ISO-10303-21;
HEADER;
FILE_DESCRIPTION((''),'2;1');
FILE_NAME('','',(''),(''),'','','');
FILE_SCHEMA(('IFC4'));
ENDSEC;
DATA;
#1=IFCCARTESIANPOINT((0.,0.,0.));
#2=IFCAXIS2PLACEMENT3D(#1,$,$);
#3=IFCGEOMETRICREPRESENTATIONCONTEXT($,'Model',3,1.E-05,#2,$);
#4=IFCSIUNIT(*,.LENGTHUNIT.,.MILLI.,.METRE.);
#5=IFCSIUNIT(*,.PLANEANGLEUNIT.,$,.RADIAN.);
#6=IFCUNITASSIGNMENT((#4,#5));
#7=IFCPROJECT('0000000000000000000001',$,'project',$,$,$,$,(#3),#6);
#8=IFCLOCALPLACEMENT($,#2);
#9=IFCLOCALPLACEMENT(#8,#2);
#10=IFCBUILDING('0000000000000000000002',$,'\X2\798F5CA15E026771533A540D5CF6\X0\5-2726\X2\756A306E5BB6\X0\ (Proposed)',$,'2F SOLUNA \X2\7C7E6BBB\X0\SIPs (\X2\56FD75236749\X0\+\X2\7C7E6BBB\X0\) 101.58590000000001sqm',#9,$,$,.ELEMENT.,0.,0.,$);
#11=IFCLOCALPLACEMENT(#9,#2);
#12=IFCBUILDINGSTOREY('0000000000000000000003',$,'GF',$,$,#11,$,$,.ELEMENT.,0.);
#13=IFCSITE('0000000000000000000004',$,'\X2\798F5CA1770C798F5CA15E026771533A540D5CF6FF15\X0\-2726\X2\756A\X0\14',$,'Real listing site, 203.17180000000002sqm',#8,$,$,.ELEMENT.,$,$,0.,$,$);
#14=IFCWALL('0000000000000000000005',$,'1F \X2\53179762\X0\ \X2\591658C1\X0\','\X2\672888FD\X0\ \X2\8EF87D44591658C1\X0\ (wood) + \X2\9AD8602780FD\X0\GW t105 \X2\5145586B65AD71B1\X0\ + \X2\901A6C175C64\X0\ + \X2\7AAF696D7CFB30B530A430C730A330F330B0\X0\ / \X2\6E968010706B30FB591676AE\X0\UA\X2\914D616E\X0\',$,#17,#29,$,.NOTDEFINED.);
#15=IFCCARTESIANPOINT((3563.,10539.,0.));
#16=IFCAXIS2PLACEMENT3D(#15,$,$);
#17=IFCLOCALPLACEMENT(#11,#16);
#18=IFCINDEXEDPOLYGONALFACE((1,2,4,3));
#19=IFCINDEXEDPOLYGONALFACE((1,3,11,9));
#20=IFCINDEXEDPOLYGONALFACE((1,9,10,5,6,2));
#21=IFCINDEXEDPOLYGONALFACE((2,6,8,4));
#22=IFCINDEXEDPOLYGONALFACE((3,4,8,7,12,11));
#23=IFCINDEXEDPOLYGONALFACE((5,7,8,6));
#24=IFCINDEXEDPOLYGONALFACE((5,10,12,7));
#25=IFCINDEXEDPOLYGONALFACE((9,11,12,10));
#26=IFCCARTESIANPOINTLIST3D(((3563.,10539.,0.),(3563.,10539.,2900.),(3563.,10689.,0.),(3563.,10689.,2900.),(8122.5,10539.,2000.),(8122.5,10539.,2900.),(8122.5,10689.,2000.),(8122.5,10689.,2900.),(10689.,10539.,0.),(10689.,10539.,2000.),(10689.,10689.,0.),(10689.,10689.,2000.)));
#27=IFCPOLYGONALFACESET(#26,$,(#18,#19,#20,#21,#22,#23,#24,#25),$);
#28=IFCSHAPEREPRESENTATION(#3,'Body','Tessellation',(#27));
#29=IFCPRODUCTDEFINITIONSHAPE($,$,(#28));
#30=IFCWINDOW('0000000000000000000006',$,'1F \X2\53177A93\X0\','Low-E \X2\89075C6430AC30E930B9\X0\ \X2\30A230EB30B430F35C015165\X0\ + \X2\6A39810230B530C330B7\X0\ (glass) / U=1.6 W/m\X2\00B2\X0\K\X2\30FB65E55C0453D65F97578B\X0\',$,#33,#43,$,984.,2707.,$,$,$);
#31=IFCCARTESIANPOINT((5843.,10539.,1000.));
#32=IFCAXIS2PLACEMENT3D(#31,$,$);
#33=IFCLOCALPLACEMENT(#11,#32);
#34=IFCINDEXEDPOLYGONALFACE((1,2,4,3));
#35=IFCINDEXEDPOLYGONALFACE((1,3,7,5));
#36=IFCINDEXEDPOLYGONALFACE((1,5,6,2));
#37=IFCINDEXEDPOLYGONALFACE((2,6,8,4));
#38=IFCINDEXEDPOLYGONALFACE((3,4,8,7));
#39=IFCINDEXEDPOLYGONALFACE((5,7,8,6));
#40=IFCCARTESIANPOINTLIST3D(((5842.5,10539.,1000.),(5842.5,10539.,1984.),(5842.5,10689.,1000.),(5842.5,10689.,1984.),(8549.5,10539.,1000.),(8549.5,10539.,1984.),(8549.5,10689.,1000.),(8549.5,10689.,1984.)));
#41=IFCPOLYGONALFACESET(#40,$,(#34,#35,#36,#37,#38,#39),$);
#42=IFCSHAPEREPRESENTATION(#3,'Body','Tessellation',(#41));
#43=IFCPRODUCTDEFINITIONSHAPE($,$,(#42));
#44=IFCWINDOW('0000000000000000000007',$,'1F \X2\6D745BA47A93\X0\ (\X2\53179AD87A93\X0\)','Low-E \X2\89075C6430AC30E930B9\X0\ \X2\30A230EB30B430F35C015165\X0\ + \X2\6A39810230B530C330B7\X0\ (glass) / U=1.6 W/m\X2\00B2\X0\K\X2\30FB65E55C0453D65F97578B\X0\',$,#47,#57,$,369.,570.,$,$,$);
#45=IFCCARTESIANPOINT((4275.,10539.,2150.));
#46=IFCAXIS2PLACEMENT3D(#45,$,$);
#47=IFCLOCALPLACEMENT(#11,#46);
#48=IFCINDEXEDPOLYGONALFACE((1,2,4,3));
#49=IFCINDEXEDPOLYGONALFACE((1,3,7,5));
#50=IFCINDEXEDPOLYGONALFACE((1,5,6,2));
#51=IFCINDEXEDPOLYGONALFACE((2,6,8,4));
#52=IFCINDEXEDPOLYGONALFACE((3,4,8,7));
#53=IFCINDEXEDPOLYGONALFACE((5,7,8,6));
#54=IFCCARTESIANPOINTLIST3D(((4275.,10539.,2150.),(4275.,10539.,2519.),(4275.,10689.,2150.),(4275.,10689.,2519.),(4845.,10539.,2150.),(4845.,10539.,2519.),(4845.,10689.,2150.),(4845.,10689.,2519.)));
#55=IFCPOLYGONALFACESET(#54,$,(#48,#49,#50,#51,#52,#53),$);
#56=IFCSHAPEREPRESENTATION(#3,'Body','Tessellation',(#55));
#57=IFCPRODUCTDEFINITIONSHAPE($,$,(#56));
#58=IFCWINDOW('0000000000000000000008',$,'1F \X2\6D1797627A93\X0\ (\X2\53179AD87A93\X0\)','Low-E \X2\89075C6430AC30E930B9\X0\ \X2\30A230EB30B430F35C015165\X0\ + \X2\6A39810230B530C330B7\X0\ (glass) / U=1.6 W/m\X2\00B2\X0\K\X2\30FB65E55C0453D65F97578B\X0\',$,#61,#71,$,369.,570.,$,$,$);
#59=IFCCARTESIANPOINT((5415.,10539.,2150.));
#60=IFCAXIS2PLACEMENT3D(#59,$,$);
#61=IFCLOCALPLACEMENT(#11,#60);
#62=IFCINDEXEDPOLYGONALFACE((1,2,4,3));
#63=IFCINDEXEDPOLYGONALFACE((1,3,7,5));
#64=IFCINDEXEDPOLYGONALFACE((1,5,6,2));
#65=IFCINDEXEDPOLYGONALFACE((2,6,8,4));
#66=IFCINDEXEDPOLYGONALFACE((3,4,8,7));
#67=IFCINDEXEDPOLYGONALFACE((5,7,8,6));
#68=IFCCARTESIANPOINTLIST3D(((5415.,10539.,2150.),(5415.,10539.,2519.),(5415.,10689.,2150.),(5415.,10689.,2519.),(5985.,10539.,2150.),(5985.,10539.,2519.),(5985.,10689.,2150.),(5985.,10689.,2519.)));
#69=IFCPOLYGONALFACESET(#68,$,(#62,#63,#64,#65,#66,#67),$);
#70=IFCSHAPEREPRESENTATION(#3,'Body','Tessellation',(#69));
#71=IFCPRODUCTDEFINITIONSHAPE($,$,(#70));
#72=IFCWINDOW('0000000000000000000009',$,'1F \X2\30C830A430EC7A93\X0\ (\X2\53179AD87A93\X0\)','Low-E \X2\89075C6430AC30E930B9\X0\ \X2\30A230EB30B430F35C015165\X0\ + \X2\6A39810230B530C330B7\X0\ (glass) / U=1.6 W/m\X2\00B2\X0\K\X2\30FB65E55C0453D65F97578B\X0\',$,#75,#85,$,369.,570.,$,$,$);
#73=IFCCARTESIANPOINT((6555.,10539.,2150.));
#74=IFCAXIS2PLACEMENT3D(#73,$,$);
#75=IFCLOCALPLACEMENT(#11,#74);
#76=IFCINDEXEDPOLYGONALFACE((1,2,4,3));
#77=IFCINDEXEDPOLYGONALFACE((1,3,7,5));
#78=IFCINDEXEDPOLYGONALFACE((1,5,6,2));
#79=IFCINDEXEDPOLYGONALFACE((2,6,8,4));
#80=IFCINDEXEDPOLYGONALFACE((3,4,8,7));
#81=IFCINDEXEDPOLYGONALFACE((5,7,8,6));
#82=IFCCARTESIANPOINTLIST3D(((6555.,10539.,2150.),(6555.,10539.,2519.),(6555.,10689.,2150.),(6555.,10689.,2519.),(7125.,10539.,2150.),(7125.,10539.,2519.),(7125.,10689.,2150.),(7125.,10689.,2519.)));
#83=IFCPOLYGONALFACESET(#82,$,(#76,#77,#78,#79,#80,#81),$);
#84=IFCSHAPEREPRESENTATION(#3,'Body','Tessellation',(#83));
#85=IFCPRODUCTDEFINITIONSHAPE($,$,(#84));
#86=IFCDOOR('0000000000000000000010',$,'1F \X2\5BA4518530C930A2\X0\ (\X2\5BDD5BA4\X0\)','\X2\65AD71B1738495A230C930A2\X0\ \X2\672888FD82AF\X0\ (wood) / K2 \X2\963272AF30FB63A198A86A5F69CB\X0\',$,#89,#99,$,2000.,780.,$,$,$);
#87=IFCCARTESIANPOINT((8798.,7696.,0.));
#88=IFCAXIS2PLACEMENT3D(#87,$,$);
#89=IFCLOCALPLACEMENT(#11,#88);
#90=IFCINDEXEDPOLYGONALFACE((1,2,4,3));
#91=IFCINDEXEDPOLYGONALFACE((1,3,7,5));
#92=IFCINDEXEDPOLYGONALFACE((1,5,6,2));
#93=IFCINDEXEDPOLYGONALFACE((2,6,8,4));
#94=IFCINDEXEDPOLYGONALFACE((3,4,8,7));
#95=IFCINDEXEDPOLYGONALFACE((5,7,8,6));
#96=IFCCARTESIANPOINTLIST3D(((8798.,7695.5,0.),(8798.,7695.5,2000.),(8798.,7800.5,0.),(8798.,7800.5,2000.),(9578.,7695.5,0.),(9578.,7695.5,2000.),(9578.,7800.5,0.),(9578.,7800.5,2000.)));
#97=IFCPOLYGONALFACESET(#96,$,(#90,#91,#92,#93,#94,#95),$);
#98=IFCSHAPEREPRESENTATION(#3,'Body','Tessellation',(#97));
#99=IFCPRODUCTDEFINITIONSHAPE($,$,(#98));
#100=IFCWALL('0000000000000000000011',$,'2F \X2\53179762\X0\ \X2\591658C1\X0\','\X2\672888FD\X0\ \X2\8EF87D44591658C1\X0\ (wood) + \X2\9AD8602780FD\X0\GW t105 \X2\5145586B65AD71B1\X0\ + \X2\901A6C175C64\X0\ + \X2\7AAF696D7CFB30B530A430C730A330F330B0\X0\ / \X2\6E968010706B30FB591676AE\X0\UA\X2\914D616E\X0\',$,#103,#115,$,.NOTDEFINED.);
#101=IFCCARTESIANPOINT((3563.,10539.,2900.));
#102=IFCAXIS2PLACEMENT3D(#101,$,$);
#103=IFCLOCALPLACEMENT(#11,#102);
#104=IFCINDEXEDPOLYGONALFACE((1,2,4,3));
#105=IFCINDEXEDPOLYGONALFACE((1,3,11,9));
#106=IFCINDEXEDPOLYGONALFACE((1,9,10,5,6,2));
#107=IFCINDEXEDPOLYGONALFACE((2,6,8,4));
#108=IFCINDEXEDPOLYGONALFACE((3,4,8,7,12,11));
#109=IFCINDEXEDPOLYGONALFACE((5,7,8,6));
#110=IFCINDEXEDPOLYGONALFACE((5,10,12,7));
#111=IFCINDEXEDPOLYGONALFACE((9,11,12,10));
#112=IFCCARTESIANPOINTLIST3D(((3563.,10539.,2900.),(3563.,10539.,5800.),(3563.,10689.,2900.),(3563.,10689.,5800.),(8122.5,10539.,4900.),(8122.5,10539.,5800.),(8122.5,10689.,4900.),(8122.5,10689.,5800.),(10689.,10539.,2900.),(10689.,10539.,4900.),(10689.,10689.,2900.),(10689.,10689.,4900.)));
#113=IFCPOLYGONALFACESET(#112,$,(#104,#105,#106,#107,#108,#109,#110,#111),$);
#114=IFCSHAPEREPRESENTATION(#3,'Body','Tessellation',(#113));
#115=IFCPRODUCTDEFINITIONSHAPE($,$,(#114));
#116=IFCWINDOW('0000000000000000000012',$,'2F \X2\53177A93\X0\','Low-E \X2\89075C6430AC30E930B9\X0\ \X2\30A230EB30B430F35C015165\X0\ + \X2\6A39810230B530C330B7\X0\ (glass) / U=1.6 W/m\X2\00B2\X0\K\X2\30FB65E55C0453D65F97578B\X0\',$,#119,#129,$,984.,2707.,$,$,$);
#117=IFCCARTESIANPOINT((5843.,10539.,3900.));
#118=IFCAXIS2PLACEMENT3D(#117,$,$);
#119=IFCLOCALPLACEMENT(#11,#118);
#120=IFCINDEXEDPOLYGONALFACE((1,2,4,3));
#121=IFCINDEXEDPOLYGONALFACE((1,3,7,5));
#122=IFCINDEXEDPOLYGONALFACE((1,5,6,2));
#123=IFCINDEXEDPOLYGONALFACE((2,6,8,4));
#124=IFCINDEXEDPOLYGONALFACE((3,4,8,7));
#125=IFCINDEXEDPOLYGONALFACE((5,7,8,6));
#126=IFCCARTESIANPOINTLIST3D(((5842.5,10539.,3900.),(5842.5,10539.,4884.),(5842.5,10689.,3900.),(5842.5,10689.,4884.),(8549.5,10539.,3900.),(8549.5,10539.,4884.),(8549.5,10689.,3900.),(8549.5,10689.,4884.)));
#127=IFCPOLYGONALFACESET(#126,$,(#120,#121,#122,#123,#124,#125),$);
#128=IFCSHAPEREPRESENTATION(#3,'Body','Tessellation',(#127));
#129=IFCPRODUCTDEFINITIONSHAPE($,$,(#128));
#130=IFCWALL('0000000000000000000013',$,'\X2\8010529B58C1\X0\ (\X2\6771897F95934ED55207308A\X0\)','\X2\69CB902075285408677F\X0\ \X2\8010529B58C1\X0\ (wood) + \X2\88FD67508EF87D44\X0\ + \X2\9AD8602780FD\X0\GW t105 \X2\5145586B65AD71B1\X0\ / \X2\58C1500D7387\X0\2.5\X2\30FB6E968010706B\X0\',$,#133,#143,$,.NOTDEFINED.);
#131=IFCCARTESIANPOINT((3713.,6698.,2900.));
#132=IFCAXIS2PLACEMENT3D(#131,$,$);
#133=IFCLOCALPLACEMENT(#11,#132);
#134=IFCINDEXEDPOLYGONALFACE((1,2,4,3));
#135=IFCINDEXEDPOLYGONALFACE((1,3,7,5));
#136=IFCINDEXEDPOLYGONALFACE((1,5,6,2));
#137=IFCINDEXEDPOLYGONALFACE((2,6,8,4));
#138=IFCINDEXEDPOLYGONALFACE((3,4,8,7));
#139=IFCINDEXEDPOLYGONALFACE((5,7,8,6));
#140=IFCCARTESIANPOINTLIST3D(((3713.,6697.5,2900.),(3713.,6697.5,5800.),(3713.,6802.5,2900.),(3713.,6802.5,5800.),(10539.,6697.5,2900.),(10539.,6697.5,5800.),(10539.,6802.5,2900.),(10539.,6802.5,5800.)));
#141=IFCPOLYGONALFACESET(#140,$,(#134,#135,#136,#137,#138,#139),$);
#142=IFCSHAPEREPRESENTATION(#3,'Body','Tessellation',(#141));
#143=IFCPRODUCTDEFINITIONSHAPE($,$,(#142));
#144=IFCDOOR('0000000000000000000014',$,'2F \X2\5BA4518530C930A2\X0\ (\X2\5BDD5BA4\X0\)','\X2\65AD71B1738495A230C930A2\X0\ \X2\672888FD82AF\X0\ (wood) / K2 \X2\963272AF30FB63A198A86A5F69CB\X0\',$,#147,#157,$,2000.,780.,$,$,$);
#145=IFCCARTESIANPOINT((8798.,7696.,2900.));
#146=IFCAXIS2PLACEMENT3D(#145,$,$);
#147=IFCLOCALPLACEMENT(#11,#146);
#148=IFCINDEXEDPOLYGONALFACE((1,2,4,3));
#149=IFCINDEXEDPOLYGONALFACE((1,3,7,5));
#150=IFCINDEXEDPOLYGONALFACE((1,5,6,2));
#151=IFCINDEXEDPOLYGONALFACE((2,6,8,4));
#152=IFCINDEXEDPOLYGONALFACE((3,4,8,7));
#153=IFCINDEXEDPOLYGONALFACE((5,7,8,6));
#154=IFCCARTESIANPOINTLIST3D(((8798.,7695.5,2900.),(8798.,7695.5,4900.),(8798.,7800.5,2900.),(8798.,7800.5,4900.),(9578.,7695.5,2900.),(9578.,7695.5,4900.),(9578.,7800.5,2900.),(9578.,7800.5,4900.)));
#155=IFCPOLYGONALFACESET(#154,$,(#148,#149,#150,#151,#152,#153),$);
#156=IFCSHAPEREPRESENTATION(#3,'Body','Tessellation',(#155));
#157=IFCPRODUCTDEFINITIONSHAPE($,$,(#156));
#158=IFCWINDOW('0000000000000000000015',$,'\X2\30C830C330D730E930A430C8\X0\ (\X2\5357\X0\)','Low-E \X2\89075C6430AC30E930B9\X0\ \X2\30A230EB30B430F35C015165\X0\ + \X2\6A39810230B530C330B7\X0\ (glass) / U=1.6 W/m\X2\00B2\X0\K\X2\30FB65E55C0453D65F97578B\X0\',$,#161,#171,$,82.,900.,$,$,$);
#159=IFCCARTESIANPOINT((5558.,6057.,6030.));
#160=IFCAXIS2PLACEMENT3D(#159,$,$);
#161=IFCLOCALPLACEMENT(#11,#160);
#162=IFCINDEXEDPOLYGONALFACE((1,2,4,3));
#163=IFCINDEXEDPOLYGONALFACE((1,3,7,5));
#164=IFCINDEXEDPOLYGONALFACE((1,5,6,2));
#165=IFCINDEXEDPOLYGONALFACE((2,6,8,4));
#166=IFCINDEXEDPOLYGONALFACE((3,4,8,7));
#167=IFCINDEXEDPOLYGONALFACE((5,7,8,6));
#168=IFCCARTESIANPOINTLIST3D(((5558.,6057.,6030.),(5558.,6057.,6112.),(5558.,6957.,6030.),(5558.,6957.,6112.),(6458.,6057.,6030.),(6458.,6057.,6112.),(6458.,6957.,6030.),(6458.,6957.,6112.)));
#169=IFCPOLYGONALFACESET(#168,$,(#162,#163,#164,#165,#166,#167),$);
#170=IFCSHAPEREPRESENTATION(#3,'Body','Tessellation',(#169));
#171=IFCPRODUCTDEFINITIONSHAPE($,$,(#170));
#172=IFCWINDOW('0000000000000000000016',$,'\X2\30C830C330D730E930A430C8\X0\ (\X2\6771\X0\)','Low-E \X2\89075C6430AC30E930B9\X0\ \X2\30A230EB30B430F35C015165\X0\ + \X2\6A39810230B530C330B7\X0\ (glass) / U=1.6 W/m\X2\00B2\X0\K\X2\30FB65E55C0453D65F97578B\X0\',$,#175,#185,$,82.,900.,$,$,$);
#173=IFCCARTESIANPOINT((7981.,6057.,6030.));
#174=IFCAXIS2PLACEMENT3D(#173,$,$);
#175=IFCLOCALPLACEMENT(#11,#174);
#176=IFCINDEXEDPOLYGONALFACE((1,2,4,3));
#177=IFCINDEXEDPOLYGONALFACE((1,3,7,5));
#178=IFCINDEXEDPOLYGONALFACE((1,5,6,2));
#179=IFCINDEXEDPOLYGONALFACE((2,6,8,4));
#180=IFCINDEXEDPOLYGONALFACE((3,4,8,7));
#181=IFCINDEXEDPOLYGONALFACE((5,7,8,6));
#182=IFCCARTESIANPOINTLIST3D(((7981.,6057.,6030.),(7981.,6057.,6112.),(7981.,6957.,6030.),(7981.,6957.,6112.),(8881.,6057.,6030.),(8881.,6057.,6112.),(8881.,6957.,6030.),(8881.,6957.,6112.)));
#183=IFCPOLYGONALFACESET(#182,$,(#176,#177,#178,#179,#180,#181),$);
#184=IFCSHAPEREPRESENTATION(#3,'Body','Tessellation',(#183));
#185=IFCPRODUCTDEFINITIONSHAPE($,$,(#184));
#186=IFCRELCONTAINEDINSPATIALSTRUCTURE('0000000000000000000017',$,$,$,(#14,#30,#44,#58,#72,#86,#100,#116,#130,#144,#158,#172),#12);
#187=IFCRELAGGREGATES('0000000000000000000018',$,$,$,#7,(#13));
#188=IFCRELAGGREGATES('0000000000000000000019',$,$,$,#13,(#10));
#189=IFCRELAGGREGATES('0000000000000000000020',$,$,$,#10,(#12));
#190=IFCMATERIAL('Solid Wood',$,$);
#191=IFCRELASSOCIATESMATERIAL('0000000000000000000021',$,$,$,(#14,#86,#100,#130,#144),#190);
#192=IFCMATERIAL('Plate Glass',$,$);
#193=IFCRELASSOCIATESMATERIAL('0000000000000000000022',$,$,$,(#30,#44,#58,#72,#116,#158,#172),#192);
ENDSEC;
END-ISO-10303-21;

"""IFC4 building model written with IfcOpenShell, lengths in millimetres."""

from ifc_helpers import new_model, si_unit, frame, frame_2d, origin, place, context, project, spatial, rectangle, extrude, material, element, fill, save


model = new_model("IFC4")

# Units and contexts
model_context = context("Model", 3, precision=1e-05, world=origin())
ifc_project = project(units=[si_unit("LENGTHUNIT", "METRE", prefix="MILLI"), si_unit("PLANEANGLEUNIT", "RADIAN")], contexts=[model_context])

# Site, building, storey
site_placement = place(None, origin())
site = spatial("IfcSite", under=ifc_project, at=site_placement, Name="福岡県福岡市東区名島５-2726番14", ObjectType="Real listing site, 203.17180000000002sqm", CompositionType="ELEMENT", RefElevation=0.0)
building_placement = place(site_placement, origin())
building = spatial("IfcBuilding", under=site, at=building_placement, Name="福岡市東区名島5-2726番の家 (Proposed)", ObjectType="2F SOLUNA 籾殻SIPs (国産杉+籾殻) 101.58590000000001sqm", CompositionType="ELEMENT", ElevationOfRefHeight=0.0, ElevationOfTerrain=0.0)
storey_placement = place(building_placement, origin())
storey = spatial("IfcBuildingStorey", under=building, at=storey_placement, Name="GF", CompositionType="ELEMENT", Elevation=0.0)

# Wall, openings, windows
ifc_material_1 = material(Name="Solid Wood")
wall_1_placement = place(storey_placement, frame((3563.0, 10539.0, 0.0)))
wall_1 = element("IfcWall", 1, at=wall_1_placement, inside=storey, material=ifc_material_1, Name="1F 北面 外壁", Description="木製 軸組外壁 (wood) + 高性能GW t105 充填断熱 + 通気層 + 窯業系サイディング / 準耐火・外皮UA配慮", PredefinedType="NOTDEFINED", context=model_context, shape_type="SweptSolid", body=[
    extrude(rectangle(XDim=7126.0, YDim=150.0, at=frame_2d((3563.0, 75.0))), frame((3563.0, 10539.0, 0.0)), (0.0, 0.0, 1.0), 2900.0),
])
opening_1_placement = place(storey_placement, frame((5843.0, 10539.0, 1000.0)))
opening_1 = element("IfcOpeningElement", 2, at=opening_1_placement, cuts=wall_1, PredefinedType="NOTDEFINED", context=model_context, shape_type="SweptSolid", body=[
    extrude(rectangle(XDim=2707.0, YDim=150.0, at=frame_2d((1353.0, 75.0))), frame((5843.0, 10539.0, 1000.0)), (0.0, 0.0, 1.0), 984.0),
])
opening_2_placement = place(storey_placement, frame((4275.0, 10539.0, 2150.0)))
opening_2 = element("IfcOpeningElement", 3, at=opening_2_placement, cuts=wall_1, PredefinedType="NOTDEFINED", context=model_context, shape_type="SweptSolid", body=[
    extrude(rectangle(XDim=570.0, YDim=150.0, at=frame_2d((285.0, 75.0))), frame((4275.0, 10539.0, 2150.0)), (0.0, 0.0, 1.0), 369.0),
])
opening_3_placement = place(storey_placement, frame((5415.0, 10539.0, 2150.0)))
opening_3 = element("IfcOpeningElement", 4, at=opening_3_placement, cuts=wall_1, PredefinedType="NOTDEFINED", context=model_context, shape_type="SweptSolid", body=[
    extrude(rectangle(XDim=570.0, YDim=150.0, at=frame_2d((285.0, 75.0))), frame((5415.0, 10539.0, 2150.0)), (0.0, 0.0, 1.0), 369.0),
])
opening_4_placement = place(storey_placement, frame((6555.0, 10539.0, 2150.0)))
opening_4 = element("IfcOpeningElement", 5, at=opening_4_placement, cuts=wall_1, PredefinedType="NOTDEFINED", context=model_context, shape_type="SweptSolid", body=[
    extrude(rectangle(XDim=570.0, YDim=150.0, at=frame_2d((285.0, 75.0))), frame((6555.0, 10539.0, 2150.0)), (0.0, 0.0, 1.0), 369.0),
])
ifc_material_2 = material(Name="Plate Glass")
window_1_placement = place(storey_placement, frame((5843.0, 10539.0, 1000.0)))
window_1 = element("IfcWindow", 6, at=window_1_placement, inside=storey, material=ifc_material_2, Name="1F 北窓", Description="Low-E 複層ガラス アルゴン封入 + 樹脂サッシ (glass) / U=1.6 W/m²K・日射取得型", OverallHeight=984.0, OverallWidth=2707.0, context=model_context, shape_type="SweptSolid", body=[
    extrude(rectangle(XDim=2707.0, YDim=150.0, at=frame_2d((1353.0, 75.0))), frame((5843.0, 10539.0, 1000.0)), (0.0, 0.0, 1.0), 984.0),
])
fill(opening_1, window_1)
window_2_placement = place(storey_placement, frame((4275.0, 10539.0, 2150.0)))
window_2 = element("IfcWindow", 7, at=window_2_placement, inside=storey, material=ifc_material_2, Name="1F 浴室窓 (北高窓)", Description="Low-E 複層ガラス アルゴン封入 + 樹脂サッシ (glass) / U=1.6 W/m²K・日射取得型", OverallHeight=369.0, OverallWidth=570.0, context=model_context, shape_type="SweptSolid", body=[
    extrude(rectangle(XDim=570.0, YDim=150.0, at=frame_2d((285.0, 75.0))), frame((4275.0, 10539.0, 2150.0)), (0.0, 0.0, 1.0), 369.0),
])
fill(opening_2, window_2)
window_3_placement = place(storey_placement, frame((5415.0, 10539.0, 2150.0)))
window_3 = element("IfcWindow", 8, at=window_3_placement, inside=storey, material=ifc_material_2, Name="1F 洗面窓 (北高窓)", Description="Low-E 複層ガラス アルゴン封入 + 樹脂サッシ (glass) / U=1.6 W/m²K・日射取得型", OverallHeight=369.0, OverallWidth=570.0, context=model_context, shape_type="SweptSolid", body=[
    extrude(rectangle(XDim=570.0, YDim=150.0, at=frame_2d((285.0, 75.0))), frame((5415.0, 10539.0, 2150.0)), (0.0, 0.0, 1.0), 369.0),
])
fill(opening_3, window_3)
window_4_placement = place(storey_placement, frame((6555.0, 10539.0, 2150.0)))
window_4 = element("IfcWindow", 9, at=window_4_placement, inside=storey, material=ifc_material_2, Name="1F トイレ窓 (北高窓)", Description="Low-E 複層ガラス アルゴン封入 + 樹脂サッシ (glass) / U=1.6 W/m²K・日射取得型", OverallHeight=369.0, OverallWidth=570.0, context=model_context, shape_type="SweptSolid", body=[
    extrude(rectangle(XDim=570.0, YDim=150.0, at=frame_2d((285.0, 75.0))), frame((6555.0, 10539.0, 2150.0)), (0.0, 0.0, 1.0), 369.0),
])
fill(opening_4, window_4)

# Door
door_1_placement = place(storey_placement, frame((8798.0, 7696.0, 0.0)))
element("IfcDoor", 10, at=door_1_placement, inside=storey, material=ifc_material_1, Name="1F 室内ドア (寝室)", Description="断熱玄関ドア 木製芯 (wood) / K2 防犯・採風機構", OverallHeight=2000.0, OverallWidth=780.0, context=model_context, shape_type="SweptSolid", body=[
    extrude(rectangle(XDim=780.0, YDim=105.0, at=frame_2d((390.0, 52.0))), frame((8798.0, 7696.0, 0.0)), (0.0, 0.0, 1.0), 2000.0),
])

# Wall, opening, window
wall_2_placement = place(storey_placement, frame((3563.0, 10539.0, 2900.0)))
wall_2 = element("IfcWall", 11, at=wall_2_placement, inside=storey, material=ifc_material_1, Name="2F 北面 外壁", Description="木製 軸組外壁 (wood) + 高性能GW t105 充填断熱 + 通気層 + 窯業系サイディング / 準耐火・外皮UA配慮", PredefinedType="NOTDEFINED", context=model_context, shape_type="SweptSolid", body=[
    extrude(rectangle(XDim=7126.0, YDim=150.0, at=frame_2d((3563.0, 75.0))), frame((3563.0, 10539.0, 2900.0)), (0.0, 0.0, 1.0), 2900.0),
])
opening_5_placement = place(storey_placement, frame((5843.0, 10539.0, 3900.0)))
opening_5 = element("IfcOpeningElement", 12, at=opening_5_placement, cuts=wall_2, PredefinedType="NOTDEFINED", context=model_context, shape_type="SweptSolid", body=[
    extrude(rectangle(XDim=2707.0, YDim=150.0, at=frame_2d((1353.0, 75.0))), frame((5843.0, 10539.0, 3900.0)), (0.0, 0.0, 1.0), 984.0),
])
window_5_placement = place(storey_placement, frame((5843.0, 10539.0, 3900.0)))
window_5 = element("IfcWindow", 13, at=window_5_placement, inside=storey, material=ifc_material_2, Name="2F 北窓", Description="Low-E 複層ガラス アルゴン封入 + 樹脂サッシ (glass) / U=1.6 W/m²K・日射取得型", OverallHeight=984.0, OverallWidth=2707.0, context=model_context, shape_type="SweptSolid", body=[
    extrude(rectangle(XDim=2707.0, YDim=150.0, at=frame_2d((1353.0, 75.0))), frame((5843.0, 10539.0, 3900.0)), (0.0, 0.0, 1.0), 984.0),
])
fill(opening_5, window_5)

# Wall
wall_3_placement = place(storey_placement, frame((3713.0, 6698.0, 2900.0)))
element("IfcWall", 14, at=wall_3_placement, inside=storey, material=ifc_material_1, Name="耐力壁 (東西間仕切り)", Description="構造用合板 耐力壁 (wood) + 製材軸組 + 高性能GW t105 充填断熱 / 壁倍率2.5・準耐火", PredefinedType="NOTDEFINED", context=model_context, shape_type="SweptSolid", body=[
    extrude(rectangle(XDim=6826.0, YDim=105.0, at=frame_2d((3413.0, 52.0))), frame((3713.0, 6698.0, 2900.0)), (0.0, 0.0, 1.0), 2900.0),
])

# Door
door_2_placement = place(storey_placement, frame((8798.0, 7696.0, 2900.0)))
element("IfcDoor", 15, at=door_2_placement, inside=storey, material=ifc_material_1, Name="2F 室内ドア (寝室)", Description="断熱玄関ドア 木製芯 (wood) / K2 防犯・採風機構", OverallHeight=2000.0, OverallWidth=780.0, context=model_context, shape_type="SweptSolid", body=[
    extrude(rectangle(XDim=780.0, YDim=105.0, at=frame_2d((390.0, 52.0))), frame((8798.0, 7696.0, 2900.0)), (0.0, 0.0, 1.0), 2000.0),
])

# Windows
window_6_placement = place(storey_placement, frame((5558.0, 6057.0, 6030.0)))
element("IfcWindow", 16, at=window_6_placement, inside=storey, material=ifc_material_2, Name="トップライト (南)", Description="Low-E 複層ガラス アルゴン封入 + 樹脂サッシ (glass) / U=1.6 W/m²K・日射取得型", OverallHeight=82.0, OverallWidth=900.0, context=model_context, shape_type="SweptSolid", body=[
    extrude(rectangle(XDim=900.0, YDim=900.0, at=frame_2d((450.0, 450.0))), frame((5558.0, 6057.0, 6030.0)), (0.0, 0.0, 1.0), 82.0),
])
window_7_placement = place(storey_placement, frame((7981.0, 6057.0, 6030.0)))
element("IfcWindow", 17, at=window_7_placement, inside=storey, material=ifc_material_2, Name="トップライト (東)", Description="Low-E 複層ガラス アルゴン封入 + 樹脂サッシ (glass) / U=1.6 W/m²K・日射取得型", OverallHeight=82.0, OverallWidth=900.0, context=model_context, shape_type="SweptSolid", body=[
    extrude(rectangle(XDim=900.0, YDim=900.0, at=frame_2d((450.0, 450.0))), frame((7981.0, 6057.0, 6030.0)), (0.0, 0.0, 1.0), 82.0),
])

save(model, "model.ifc")
